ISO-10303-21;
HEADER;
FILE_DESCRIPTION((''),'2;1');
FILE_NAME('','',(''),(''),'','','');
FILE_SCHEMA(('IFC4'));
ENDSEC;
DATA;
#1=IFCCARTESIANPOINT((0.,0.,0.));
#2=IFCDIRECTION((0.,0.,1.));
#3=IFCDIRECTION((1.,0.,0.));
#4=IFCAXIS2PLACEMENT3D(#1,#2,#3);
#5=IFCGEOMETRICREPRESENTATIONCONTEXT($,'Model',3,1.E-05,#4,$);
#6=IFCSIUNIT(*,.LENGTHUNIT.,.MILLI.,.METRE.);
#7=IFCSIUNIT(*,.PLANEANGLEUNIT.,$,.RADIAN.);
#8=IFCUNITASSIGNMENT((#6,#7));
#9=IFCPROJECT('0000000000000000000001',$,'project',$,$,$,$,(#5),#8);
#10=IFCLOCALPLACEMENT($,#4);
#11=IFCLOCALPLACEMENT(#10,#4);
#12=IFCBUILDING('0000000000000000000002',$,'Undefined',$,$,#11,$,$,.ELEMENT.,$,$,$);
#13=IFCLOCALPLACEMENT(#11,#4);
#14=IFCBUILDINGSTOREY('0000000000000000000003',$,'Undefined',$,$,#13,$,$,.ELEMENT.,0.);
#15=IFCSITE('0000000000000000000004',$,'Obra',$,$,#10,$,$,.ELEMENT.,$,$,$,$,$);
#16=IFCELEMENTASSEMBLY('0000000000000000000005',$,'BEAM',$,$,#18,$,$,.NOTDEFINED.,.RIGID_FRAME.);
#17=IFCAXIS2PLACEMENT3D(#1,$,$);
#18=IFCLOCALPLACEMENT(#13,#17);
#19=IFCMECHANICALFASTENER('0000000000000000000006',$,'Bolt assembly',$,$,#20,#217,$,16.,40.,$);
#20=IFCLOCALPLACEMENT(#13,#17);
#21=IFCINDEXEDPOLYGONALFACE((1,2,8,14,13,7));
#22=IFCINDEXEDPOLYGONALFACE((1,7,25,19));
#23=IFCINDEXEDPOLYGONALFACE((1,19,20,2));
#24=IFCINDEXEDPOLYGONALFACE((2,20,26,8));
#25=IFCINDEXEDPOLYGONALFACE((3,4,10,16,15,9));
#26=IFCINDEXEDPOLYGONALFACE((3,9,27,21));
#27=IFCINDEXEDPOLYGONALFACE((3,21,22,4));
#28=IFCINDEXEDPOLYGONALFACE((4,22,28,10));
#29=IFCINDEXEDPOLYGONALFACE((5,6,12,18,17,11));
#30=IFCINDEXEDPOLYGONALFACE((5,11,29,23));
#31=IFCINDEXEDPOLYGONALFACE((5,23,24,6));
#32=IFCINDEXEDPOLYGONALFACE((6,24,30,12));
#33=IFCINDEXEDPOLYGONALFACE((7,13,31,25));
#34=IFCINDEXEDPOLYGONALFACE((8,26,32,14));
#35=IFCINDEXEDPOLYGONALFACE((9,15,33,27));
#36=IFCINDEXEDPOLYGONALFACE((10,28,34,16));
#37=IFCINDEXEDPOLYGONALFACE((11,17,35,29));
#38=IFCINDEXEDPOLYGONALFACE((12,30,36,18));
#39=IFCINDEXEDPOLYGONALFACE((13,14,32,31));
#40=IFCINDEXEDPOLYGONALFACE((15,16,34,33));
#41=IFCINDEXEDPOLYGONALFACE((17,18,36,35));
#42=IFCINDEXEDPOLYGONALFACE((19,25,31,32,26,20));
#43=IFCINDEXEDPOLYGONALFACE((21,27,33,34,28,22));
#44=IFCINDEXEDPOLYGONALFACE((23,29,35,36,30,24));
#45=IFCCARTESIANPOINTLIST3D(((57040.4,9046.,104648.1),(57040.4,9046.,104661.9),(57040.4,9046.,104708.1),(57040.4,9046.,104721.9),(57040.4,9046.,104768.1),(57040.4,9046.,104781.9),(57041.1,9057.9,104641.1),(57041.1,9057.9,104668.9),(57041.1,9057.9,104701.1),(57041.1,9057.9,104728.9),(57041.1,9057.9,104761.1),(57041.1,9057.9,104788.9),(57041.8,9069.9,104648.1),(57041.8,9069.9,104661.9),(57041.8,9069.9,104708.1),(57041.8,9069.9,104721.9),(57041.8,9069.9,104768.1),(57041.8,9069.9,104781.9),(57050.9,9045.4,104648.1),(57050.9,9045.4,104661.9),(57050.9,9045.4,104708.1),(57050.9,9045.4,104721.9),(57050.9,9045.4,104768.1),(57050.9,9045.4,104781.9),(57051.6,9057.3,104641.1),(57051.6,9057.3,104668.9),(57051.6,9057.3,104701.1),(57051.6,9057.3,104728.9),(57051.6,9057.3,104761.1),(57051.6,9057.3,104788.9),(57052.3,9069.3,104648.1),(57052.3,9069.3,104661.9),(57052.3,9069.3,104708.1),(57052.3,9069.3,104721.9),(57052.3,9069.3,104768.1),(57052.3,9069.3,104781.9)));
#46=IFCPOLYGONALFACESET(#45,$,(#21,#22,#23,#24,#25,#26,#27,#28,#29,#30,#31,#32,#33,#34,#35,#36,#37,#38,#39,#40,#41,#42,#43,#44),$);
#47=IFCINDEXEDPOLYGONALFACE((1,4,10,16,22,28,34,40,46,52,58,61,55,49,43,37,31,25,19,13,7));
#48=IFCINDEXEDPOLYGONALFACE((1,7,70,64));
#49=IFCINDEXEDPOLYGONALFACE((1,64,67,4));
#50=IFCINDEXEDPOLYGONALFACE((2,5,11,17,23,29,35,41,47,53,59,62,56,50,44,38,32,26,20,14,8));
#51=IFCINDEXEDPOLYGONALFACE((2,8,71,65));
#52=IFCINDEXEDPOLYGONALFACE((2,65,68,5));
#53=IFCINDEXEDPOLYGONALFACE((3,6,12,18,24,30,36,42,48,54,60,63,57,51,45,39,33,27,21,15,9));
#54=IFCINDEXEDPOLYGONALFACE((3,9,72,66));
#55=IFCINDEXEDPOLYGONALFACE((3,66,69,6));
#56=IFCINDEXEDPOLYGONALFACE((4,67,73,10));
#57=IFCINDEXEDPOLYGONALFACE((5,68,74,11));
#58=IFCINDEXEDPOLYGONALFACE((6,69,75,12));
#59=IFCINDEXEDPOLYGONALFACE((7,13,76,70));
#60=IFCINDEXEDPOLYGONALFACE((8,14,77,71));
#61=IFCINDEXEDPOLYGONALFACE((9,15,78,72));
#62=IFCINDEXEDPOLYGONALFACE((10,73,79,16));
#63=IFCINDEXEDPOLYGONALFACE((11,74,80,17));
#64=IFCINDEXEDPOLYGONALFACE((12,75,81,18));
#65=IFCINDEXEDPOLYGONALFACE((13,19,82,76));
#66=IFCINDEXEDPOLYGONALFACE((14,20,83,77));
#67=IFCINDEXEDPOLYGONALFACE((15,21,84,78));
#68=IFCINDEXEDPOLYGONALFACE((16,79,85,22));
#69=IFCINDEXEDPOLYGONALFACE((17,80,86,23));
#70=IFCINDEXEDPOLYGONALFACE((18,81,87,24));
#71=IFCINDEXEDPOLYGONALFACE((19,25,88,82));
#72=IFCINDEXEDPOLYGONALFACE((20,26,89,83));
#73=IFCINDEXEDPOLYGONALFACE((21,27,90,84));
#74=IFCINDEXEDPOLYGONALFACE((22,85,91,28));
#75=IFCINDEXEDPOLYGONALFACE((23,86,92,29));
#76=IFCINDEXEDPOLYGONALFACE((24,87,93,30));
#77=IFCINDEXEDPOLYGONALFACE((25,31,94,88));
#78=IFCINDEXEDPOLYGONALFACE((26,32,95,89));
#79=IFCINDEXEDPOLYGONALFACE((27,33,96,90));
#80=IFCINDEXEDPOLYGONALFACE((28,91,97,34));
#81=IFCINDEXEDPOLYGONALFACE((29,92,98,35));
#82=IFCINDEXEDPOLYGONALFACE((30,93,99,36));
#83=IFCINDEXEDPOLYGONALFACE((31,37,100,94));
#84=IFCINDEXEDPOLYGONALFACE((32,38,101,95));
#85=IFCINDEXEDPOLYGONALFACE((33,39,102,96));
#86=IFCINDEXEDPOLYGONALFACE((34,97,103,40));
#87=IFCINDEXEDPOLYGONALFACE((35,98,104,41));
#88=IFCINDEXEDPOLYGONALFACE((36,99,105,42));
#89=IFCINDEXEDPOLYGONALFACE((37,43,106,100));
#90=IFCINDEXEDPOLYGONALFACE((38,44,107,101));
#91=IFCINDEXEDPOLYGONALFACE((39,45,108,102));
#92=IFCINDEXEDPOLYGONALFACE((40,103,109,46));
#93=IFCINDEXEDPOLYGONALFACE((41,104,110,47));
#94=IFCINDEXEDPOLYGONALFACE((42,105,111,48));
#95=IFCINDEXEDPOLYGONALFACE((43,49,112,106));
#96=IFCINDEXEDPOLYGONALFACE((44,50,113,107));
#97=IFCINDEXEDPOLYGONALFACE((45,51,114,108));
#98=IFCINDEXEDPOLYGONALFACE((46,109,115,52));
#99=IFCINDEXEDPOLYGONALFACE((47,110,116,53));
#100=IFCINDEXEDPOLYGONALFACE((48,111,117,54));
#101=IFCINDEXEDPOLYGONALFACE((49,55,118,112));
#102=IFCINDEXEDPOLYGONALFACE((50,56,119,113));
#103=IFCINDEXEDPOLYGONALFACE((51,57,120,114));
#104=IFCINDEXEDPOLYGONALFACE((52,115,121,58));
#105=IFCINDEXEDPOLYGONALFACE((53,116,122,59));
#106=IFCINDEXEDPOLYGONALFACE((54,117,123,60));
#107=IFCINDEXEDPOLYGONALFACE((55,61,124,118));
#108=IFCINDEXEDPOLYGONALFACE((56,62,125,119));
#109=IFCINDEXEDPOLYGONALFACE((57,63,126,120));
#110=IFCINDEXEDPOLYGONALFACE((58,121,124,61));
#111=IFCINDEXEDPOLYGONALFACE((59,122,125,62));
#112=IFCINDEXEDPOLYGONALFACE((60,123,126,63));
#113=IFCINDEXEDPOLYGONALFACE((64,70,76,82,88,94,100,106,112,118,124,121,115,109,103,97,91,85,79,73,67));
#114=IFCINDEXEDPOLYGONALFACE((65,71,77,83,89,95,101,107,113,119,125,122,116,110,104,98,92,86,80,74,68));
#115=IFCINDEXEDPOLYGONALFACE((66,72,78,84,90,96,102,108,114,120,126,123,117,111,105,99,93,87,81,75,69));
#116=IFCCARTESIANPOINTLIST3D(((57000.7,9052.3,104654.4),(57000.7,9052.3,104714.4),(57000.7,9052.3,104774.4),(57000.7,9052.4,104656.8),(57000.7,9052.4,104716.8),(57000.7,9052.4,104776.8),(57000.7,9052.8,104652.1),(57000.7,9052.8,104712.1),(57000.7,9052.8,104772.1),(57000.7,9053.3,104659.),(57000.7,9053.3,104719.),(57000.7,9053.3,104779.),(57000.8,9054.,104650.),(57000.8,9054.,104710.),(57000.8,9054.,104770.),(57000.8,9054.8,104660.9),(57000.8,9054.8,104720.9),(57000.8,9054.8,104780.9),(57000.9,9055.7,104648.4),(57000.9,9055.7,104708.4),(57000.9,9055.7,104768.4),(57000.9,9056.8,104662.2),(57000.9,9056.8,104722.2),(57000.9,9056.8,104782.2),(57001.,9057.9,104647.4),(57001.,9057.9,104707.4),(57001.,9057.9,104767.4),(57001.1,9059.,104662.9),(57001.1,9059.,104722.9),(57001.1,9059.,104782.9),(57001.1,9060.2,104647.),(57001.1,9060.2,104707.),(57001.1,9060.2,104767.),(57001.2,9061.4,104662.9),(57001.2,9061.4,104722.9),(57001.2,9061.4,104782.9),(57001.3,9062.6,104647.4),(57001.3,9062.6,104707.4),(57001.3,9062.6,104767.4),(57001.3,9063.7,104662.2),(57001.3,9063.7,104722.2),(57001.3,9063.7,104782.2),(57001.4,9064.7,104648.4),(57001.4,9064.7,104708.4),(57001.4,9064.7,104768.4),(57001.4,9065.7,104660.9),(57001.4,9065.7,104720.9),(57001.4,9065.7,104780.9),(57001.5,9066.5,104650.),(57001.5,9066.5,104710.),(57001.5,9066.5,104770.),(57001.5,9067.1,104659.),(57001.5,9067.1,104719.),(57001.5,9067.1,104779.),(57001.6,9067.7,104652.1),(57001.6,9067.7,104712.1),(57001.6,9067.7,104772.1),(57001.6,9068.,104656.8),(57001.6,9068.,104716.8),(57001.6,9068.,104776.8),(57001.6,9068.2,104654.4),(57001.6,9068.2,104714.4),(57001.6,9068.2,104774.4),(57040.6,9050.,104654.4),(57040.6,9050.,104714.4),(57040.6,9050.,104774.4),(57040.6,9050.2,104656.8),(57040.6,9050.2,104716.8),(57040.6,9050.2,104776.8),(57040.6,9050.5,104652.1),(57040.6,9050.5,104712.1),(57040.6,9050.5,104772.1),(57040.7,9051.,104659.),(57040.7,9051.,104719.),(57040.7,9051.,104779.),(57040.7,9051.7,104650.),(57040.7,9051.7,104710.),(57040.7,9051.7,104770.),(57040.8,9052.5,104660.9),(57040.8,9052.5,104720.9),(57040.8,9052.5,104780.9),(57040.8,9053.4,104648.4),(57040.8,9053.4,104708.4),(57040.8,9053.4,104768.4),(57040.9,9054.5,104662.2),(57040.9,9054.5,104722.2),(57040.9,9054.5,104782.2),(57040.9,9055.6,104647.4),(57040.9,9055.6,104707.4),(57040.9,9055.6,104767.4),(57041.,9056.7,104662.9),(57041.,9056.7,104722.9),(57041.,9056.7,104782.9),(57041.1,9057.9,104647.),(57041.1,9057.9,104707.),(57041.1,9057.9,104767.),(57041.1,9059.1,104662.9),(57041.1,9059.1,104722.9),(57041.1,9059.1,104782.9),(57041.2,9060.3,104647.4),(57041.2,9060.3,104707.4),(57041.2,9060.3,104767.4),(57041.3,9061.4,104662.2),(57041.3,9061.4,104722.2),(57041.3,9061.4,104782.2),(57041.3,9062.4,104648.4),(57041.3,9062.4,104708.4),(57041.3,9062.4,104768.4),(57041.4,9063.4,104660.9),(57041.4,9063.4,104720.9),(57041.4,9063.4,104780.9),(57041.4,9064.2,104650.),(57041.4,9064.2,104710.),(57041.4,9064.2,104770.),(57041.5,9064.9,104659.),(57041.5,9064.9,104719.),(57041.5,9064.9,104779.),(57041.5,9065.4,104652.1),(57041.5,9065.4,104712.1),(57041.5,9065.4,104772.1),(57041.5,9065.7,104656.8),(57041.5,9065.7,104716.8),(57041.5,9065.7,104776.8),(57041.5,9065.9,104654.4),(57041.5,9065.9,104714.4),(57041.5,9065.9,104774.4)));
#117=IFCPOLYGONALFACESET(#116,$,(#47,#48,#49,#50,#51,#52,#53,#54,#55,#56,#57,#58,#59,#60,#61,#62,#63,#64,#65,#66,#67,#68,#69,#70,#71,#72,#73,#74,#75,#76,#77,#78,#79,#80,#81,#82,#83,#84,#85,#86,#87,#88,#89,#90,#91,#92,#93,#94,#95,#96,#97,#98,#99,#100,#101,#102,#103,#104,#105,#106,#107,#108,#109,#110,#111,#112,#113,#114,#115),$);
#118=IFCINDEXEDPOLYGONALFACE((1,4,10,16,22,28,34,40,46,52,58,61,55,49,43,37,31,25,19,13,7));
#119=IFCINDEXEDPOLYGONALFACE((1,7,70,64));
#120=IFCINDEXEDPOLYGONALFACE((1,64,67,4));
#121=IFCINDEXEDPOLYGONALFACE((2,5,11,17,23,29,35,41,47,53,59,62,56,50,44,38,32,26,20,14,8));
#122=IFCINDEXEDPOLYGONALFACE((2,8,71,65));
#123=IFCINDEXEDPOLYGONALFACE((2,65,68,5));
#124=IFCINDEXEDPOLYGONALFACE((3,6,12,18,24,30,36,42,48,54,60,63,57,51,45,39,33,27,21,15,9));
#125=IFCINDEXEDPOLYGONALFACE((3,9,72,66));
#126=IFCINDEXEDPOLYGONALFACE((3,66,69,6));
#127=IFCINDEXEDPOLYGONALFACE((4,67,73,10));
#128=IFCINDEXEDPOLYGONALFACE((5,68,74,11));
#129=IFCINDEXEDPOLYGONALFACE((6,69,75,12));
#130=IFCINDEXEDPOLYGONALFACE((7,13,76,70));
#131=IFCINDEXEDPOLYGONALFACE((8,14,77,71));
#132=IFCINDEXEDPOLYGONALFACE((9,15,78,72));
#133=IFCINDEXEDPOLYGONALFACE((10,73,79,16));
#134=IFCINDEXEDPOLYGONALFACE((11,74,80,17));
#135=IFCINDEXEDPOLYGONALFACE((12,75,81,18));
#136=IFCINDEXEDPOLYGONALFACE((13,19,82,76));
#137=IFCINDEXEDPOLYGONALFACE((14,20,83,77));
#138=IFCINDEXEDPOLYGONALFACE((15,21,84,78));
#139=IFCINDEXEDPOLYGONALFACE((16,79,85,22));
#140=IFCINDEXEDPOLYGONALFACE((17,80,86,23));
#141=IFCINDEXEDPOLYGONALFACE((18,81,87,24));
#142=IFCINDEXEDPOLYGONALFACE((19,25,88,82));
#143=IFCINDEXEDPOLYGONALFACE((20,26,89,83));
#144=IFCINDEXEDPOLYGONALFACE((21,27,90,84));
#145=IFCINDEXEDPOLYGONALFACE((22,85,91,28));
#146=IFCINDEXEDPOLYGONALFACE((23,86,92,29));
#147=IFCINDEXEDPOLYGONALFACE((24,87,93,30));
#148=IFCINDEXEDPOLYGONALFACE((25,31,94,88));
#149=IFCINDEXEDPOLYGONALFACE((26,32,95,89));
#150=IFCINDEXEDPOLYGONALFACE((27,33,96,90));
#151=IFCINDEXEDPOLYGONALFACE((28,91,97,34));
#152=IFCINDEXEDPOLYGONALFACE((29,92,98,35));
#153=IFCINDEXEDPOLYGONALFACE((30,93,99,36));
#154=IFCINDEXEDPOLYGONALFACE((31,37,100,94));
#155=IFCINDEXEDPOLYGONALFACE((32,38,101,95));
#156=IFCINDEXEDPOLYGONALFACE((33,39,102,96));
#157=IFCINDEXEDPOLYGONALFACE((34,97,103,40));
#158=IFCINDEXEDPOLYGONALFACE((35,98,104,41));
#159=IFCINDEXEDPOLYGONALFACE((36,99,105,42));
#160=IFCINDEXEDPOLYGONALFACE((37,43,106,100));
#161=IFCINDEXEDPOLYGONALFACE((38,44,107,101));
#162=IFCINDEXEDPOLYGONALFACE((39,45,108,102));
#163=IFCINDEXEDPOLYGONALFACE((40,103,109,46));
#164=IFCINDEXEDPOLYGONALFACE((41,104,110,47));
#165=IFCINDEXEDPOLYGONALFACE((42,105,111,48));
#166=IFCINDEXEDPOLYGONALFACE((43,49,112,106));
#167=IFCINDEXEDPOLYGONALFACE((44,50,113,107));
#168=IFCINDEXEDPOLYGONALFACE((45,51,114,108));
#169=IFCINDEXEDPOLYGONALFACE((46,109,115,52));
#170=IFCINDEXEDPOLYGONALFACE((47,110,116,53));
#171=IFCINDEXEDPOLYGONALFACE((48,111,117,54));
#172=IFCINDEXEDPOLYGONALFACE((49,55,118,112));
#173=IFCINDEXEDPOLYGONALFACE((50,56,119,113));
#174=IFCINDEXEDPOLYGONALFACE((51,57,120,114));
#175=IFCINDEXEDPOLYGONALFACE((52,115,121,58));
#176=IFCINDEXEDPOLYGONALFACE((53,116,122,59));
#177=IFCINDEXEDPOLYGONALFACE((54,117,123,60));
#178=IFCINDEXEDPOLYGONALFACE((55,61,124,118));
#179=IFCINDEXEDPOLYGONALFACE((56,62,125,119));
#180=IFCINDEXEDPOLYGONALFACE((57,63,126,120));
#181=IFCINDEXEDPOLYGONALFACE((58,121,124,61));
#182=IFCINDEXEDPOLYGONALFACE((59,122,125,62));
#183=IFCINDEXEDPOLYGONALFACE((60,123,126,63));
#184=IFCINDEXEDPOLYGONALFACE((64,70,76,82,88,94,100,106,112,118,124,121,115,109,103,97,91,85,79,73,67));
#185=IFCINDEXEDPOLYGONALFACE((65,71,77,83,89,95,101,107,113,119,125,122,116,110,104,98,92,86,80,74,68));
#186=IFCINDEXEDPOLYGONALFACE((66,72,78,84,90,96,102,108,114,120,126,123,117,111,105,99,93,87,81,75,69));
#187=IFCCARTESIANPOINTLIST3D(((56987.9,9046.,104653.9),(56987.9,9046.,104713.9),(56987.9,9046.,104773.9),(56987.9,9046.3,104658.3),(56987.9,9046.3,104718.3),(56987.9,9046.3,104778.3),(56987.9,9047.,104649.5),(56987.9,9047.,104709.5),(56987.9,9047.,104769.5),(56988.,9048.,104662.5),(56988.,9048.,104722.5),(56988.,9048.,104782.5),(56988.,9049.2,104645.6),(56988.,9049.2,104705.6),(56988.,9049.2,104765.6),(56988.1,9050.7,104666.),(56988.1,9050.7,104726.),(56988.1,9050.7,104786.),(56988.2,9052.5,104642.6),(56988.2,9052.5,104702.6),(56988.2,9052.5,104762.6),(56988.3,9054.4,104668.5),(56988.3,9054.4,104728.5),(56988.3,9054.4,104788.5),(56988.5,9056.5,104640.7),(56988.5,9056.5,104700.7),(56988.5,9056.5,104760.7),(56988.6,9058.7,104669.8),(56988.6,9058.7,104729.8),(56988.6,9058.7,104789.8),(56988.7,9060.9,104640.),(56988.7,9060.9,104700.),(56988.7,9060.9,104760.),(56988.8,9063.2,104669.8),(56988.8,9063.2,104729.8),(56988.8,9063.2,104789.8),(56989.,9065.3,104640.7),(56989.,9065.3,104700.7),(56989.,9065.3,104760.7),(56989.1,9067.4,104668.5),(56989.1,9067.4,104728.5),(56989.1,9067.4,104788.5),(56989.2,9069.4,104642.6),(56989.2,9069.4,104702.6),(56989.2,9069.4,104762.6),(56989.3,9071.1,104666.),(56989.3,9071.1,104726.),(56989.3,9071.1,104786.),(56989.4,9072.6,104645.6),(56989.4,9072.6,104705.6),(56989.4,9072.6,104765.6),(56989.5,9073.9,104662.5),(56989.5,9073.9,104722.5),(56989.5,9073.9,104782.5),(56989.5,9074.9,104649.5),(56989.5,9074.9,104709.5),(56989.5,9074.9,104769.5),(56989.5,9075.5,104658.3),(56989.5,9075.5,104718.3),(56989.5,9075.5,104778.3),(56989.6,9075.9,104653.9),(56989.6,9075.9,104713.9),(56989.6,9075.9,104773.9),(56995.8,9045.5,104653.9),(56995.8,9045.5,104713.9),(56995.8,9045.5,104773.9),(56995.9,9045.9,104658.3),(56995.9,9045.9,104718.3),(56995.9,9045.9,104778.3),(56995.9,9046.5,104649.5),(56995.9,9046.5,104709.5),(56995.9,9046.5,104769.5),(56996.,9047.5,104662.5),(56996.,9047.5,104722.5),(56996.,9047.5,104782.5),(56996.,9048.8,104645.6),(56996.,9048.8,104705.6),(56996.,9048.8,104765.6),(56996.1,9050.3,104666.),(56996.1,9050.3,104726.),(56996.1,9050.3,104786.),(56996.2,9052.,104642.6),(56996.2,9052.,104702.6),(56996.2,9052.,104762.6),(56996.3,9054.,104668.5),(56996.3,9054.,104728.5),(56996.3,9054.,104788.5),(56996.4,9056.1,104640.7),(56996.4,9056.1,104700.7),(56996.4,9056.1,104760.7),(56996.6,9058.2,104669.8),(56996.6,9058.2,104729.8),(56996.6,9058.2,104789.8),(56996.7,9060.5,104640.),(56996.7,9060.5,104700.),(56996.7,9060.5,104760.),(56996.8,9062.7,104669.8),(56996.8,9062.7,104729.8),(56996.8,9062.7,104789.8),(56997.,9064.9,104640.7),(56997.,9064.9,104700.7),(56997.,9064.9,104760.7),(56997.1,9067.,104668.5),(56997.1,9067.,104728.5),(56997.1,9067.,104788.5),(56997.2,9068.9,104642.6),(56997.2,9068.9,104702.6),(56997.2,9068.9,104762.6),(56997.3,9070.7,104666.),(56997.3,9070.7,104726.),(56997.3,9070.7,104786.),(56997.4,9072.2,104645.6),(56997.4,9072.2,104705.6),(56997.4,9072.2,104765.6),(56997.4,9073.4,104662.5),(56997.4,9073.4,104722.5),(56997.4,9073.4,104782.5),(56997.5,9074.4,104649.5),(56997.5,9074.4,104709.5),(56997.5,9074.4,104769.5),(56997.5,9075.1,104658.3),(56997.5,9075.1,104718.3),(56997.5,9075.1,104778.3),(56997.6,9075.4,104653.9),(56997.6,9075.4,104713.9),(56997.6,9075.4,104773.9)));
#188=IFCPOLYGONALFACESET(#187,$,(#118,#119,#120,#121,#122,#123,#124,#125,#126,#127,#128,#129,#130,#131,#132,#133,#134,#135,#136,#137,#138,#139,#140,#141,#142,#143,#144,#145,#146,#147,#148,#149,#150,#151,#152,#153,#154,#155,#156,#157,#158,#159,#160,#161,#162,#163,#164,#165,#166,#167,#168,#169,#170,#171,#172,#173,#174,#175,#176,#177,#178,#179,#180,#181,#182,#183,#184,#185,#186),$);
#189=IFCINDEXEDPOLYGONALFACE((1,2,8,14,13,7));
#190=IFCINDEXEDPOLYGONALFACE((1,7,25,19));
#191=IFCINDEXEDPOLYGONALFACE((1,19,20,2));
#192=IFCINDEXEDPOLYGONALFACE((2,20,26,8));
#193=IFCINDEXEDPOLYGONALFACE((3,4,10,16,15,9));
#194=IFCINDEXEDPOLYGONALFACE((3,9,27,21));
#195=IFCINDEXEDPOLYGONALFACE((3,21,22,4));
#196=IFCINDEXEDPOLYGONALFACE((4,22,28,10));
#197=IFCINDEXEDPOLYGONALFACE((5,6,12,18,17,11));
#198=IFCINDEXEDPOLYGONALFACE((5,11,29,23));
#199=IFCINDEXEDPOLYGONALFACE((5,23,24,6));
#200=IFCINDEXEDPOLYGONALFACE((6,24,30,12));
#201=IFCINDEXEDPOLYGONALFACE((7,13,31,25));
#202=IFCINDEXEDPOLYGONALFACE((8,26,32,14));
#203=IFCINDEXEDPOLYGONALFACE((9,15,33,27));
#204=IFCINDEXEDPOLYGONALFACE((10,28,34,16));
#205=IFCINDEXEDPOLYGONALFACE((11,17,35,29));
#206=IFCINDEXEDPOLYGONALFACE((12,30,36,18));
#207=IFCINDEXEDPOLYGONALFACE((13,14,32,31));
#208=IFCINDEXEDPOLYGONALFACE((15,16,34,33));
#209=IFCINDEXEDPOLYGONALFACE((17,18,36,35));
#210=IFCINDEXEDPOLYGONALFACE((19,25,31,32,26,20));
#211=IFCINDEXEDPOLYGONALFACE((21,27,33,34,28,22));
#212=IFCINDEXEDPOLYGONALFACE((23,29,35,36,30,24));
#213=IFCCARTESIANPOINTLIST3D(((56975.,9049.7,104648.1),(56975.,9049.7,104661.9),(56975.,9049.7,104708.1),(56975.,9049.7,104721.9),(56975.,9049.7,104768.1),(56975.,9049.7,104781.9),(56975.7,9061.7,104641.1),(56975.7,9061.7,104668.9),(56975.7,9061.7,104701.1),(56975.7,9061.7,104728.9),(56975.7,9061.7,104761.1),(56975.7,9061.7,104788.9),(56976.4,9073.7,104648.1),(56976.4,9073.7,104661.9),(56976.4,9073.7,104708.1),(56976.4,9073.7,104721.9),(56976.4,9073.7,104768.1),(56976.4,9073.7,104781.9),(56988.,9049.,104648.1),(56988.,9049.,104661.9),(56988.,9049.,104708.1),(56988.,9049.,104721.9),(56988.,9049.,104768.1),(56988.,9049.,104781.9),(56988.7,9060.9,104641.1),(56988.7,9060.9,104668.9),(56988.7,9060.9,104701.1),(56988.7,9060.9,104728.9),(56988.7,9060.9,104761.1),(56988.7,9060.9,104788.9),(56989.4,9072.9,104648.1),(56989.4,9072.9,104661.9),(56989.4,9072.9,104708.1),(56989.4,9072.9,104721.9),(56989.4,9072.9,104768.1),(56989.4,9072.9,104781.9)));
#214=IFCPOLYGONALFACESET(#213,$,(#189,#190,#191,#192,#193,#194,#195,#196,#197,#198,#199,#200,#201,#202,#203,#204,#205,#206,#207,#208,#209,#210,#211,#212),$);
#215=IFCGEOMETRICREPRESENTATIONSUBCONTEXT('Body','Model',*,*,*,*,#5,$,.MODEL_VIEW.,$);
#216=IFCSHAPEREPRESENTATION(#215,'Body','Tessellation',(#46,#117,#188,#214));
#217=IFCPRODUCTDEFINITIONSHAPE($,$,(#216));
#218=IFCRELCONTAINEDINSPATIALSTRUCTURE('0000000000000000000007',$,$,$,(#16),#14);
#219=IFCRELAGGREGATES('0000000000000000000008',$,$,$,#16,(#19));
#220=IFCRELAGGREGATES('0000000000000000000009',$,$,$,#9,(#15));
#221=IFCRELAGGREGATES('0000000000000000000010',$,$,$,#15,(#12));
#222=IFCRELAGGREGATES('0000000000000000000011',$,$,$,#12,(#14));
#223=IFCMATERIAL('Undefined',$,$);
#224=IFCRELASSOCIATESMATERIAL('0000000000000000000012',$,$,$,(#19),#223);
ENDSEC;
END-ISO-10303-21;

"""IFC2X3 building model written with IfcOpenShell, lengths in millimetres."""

from ifc_helpers import new_model, si_unit, frame, origin_with_axes, origin_2d_with_axis, place, context, subcontext, project, spatial, polyline, circle, outline, extrude, source, transform, mapped, material, element, aggregate, save


model = new_model("IFC2X3")

# Units and contexts
model_context = context("Model", 3, precision=1e-05, world=origin_with_axes())
body_context = subcontext(model_context, "Body", "Model", "MODEL_VIEW")
ifc_project = project(units=[si_unit("LENGTHUNIT", "METRE", prefix="MILLI"), si_unit("PLANEANGLEUNIT", "RADIAN")], contexts=[model_context])

# Site, building, storey
site_placement = place(None, origin_with_axes())
site = spatial("IfcSite", under=ifc_project, at=site_placement, Name="Obra", CompositionType="ELEMENT")
building_placement = place(site_placement, origin_with_axes())
building = spatial("IfcBuilding", under=site, at=building_placement, Name="Undefined", CompositionType="ELEMENT")
storey_placement = place(building_placement, origin_with_axes())
storey = spatial("IfcBuildingStorey", under=building, at=storey_placement, Name="Undefined", CompositionType="ELEMENT", Elevation=0.0)

# Element assembly
assembly_1_placement = place(storey_placement, origin_with_axes())
assembly_1 = element("IfcElementAssembly", 1, at=assembly_1_placement, inside=storey, Name="BEAM", AssemblyPlace="NOTDEFINED", PredefinedType="RIGID_FRAME")

# Shared definitions
ifc_material_1 = material(Name="Undefined")

# Mechanical fastener
shared_shape_1 = source(origin_with_axes(), body_context, "Body", "SweptSolid", [
    extrude(outline(polyline([(13.9, 0.0), (6.9, 12.0), (-6.9, 12.0), (-13.9, 0.0), (-6.9, -12.0), (6.9, -12.0), (13.9, 0.0)])), frame((0.0, -19.7, 0.0), z_axis=(0.0, 1.0, 0.0), x_axis=(1.0, 0.0, 0.0)), (0.0, 0.0, 1.0), 10.6),
    extrude(circle(Radius=8.0, at=origin_2d_with_axis()), frame((0.0, -9.1, 0.0), z_axis=(0.0, 1.0, 0.0), x_axis=(1.0, 0.0, 0.0)), (0.0, 0.0, 1.0), 40.0),
    extrude(circle(Radius=15.0, at=origin_2d_with_axis()), frame((0.0, 35.3, 0.0), z_axis=(0.0, 1.0, 0.0), x_axis=(1.0, 0.0, 0.0)), (0.0, 0.0, 1.0), 8.0),
    extrude(outline(polyline([(13.9, 0.0), (6.9, 12.0), (-6.9, 12.0), (-13.9, 0.0), (-6.9, -12.0), (6.9, -12.0), (13.9, 0.0)])), frame((0.0, 43.3, 0.0), z_axis=(0.0, 1.0, 0.0), x_axis=(1.0, 0.0, 0.0)), (0.0, 0.0, 1.0), 13.0),
])
mechanical_fastener_1_placement = place(assembly_1_placement, frame((57029.1, 9008.5, 104835.0), z_axis=(0.05711, 0.998368, 0.0), x_axis=(0.0, 0.0, -1.0)))
mechanical_fastener_1 = element("IfcMechanicalFastener", 2, at=mechanical_fastener_1_placement, material=ifc_material_1, Name="Bolt assembly", NominalDiameter=16.0, NominalLength=40.0, context=body_context, shape_type="MappedRepresentation", body=[
    mapped(shared_shape_1, transform((60.0, 0.0, 50.0))),
    mapped(shared_shape_1, transform((120.0, 0.0, 50.0))),
    mapped(shared_shape_1, transform((180.0, 0.0, 50.0))),
])
aggregate(assembly_1, [mechanical_fastener_1])

save(model, "model.ifc")
